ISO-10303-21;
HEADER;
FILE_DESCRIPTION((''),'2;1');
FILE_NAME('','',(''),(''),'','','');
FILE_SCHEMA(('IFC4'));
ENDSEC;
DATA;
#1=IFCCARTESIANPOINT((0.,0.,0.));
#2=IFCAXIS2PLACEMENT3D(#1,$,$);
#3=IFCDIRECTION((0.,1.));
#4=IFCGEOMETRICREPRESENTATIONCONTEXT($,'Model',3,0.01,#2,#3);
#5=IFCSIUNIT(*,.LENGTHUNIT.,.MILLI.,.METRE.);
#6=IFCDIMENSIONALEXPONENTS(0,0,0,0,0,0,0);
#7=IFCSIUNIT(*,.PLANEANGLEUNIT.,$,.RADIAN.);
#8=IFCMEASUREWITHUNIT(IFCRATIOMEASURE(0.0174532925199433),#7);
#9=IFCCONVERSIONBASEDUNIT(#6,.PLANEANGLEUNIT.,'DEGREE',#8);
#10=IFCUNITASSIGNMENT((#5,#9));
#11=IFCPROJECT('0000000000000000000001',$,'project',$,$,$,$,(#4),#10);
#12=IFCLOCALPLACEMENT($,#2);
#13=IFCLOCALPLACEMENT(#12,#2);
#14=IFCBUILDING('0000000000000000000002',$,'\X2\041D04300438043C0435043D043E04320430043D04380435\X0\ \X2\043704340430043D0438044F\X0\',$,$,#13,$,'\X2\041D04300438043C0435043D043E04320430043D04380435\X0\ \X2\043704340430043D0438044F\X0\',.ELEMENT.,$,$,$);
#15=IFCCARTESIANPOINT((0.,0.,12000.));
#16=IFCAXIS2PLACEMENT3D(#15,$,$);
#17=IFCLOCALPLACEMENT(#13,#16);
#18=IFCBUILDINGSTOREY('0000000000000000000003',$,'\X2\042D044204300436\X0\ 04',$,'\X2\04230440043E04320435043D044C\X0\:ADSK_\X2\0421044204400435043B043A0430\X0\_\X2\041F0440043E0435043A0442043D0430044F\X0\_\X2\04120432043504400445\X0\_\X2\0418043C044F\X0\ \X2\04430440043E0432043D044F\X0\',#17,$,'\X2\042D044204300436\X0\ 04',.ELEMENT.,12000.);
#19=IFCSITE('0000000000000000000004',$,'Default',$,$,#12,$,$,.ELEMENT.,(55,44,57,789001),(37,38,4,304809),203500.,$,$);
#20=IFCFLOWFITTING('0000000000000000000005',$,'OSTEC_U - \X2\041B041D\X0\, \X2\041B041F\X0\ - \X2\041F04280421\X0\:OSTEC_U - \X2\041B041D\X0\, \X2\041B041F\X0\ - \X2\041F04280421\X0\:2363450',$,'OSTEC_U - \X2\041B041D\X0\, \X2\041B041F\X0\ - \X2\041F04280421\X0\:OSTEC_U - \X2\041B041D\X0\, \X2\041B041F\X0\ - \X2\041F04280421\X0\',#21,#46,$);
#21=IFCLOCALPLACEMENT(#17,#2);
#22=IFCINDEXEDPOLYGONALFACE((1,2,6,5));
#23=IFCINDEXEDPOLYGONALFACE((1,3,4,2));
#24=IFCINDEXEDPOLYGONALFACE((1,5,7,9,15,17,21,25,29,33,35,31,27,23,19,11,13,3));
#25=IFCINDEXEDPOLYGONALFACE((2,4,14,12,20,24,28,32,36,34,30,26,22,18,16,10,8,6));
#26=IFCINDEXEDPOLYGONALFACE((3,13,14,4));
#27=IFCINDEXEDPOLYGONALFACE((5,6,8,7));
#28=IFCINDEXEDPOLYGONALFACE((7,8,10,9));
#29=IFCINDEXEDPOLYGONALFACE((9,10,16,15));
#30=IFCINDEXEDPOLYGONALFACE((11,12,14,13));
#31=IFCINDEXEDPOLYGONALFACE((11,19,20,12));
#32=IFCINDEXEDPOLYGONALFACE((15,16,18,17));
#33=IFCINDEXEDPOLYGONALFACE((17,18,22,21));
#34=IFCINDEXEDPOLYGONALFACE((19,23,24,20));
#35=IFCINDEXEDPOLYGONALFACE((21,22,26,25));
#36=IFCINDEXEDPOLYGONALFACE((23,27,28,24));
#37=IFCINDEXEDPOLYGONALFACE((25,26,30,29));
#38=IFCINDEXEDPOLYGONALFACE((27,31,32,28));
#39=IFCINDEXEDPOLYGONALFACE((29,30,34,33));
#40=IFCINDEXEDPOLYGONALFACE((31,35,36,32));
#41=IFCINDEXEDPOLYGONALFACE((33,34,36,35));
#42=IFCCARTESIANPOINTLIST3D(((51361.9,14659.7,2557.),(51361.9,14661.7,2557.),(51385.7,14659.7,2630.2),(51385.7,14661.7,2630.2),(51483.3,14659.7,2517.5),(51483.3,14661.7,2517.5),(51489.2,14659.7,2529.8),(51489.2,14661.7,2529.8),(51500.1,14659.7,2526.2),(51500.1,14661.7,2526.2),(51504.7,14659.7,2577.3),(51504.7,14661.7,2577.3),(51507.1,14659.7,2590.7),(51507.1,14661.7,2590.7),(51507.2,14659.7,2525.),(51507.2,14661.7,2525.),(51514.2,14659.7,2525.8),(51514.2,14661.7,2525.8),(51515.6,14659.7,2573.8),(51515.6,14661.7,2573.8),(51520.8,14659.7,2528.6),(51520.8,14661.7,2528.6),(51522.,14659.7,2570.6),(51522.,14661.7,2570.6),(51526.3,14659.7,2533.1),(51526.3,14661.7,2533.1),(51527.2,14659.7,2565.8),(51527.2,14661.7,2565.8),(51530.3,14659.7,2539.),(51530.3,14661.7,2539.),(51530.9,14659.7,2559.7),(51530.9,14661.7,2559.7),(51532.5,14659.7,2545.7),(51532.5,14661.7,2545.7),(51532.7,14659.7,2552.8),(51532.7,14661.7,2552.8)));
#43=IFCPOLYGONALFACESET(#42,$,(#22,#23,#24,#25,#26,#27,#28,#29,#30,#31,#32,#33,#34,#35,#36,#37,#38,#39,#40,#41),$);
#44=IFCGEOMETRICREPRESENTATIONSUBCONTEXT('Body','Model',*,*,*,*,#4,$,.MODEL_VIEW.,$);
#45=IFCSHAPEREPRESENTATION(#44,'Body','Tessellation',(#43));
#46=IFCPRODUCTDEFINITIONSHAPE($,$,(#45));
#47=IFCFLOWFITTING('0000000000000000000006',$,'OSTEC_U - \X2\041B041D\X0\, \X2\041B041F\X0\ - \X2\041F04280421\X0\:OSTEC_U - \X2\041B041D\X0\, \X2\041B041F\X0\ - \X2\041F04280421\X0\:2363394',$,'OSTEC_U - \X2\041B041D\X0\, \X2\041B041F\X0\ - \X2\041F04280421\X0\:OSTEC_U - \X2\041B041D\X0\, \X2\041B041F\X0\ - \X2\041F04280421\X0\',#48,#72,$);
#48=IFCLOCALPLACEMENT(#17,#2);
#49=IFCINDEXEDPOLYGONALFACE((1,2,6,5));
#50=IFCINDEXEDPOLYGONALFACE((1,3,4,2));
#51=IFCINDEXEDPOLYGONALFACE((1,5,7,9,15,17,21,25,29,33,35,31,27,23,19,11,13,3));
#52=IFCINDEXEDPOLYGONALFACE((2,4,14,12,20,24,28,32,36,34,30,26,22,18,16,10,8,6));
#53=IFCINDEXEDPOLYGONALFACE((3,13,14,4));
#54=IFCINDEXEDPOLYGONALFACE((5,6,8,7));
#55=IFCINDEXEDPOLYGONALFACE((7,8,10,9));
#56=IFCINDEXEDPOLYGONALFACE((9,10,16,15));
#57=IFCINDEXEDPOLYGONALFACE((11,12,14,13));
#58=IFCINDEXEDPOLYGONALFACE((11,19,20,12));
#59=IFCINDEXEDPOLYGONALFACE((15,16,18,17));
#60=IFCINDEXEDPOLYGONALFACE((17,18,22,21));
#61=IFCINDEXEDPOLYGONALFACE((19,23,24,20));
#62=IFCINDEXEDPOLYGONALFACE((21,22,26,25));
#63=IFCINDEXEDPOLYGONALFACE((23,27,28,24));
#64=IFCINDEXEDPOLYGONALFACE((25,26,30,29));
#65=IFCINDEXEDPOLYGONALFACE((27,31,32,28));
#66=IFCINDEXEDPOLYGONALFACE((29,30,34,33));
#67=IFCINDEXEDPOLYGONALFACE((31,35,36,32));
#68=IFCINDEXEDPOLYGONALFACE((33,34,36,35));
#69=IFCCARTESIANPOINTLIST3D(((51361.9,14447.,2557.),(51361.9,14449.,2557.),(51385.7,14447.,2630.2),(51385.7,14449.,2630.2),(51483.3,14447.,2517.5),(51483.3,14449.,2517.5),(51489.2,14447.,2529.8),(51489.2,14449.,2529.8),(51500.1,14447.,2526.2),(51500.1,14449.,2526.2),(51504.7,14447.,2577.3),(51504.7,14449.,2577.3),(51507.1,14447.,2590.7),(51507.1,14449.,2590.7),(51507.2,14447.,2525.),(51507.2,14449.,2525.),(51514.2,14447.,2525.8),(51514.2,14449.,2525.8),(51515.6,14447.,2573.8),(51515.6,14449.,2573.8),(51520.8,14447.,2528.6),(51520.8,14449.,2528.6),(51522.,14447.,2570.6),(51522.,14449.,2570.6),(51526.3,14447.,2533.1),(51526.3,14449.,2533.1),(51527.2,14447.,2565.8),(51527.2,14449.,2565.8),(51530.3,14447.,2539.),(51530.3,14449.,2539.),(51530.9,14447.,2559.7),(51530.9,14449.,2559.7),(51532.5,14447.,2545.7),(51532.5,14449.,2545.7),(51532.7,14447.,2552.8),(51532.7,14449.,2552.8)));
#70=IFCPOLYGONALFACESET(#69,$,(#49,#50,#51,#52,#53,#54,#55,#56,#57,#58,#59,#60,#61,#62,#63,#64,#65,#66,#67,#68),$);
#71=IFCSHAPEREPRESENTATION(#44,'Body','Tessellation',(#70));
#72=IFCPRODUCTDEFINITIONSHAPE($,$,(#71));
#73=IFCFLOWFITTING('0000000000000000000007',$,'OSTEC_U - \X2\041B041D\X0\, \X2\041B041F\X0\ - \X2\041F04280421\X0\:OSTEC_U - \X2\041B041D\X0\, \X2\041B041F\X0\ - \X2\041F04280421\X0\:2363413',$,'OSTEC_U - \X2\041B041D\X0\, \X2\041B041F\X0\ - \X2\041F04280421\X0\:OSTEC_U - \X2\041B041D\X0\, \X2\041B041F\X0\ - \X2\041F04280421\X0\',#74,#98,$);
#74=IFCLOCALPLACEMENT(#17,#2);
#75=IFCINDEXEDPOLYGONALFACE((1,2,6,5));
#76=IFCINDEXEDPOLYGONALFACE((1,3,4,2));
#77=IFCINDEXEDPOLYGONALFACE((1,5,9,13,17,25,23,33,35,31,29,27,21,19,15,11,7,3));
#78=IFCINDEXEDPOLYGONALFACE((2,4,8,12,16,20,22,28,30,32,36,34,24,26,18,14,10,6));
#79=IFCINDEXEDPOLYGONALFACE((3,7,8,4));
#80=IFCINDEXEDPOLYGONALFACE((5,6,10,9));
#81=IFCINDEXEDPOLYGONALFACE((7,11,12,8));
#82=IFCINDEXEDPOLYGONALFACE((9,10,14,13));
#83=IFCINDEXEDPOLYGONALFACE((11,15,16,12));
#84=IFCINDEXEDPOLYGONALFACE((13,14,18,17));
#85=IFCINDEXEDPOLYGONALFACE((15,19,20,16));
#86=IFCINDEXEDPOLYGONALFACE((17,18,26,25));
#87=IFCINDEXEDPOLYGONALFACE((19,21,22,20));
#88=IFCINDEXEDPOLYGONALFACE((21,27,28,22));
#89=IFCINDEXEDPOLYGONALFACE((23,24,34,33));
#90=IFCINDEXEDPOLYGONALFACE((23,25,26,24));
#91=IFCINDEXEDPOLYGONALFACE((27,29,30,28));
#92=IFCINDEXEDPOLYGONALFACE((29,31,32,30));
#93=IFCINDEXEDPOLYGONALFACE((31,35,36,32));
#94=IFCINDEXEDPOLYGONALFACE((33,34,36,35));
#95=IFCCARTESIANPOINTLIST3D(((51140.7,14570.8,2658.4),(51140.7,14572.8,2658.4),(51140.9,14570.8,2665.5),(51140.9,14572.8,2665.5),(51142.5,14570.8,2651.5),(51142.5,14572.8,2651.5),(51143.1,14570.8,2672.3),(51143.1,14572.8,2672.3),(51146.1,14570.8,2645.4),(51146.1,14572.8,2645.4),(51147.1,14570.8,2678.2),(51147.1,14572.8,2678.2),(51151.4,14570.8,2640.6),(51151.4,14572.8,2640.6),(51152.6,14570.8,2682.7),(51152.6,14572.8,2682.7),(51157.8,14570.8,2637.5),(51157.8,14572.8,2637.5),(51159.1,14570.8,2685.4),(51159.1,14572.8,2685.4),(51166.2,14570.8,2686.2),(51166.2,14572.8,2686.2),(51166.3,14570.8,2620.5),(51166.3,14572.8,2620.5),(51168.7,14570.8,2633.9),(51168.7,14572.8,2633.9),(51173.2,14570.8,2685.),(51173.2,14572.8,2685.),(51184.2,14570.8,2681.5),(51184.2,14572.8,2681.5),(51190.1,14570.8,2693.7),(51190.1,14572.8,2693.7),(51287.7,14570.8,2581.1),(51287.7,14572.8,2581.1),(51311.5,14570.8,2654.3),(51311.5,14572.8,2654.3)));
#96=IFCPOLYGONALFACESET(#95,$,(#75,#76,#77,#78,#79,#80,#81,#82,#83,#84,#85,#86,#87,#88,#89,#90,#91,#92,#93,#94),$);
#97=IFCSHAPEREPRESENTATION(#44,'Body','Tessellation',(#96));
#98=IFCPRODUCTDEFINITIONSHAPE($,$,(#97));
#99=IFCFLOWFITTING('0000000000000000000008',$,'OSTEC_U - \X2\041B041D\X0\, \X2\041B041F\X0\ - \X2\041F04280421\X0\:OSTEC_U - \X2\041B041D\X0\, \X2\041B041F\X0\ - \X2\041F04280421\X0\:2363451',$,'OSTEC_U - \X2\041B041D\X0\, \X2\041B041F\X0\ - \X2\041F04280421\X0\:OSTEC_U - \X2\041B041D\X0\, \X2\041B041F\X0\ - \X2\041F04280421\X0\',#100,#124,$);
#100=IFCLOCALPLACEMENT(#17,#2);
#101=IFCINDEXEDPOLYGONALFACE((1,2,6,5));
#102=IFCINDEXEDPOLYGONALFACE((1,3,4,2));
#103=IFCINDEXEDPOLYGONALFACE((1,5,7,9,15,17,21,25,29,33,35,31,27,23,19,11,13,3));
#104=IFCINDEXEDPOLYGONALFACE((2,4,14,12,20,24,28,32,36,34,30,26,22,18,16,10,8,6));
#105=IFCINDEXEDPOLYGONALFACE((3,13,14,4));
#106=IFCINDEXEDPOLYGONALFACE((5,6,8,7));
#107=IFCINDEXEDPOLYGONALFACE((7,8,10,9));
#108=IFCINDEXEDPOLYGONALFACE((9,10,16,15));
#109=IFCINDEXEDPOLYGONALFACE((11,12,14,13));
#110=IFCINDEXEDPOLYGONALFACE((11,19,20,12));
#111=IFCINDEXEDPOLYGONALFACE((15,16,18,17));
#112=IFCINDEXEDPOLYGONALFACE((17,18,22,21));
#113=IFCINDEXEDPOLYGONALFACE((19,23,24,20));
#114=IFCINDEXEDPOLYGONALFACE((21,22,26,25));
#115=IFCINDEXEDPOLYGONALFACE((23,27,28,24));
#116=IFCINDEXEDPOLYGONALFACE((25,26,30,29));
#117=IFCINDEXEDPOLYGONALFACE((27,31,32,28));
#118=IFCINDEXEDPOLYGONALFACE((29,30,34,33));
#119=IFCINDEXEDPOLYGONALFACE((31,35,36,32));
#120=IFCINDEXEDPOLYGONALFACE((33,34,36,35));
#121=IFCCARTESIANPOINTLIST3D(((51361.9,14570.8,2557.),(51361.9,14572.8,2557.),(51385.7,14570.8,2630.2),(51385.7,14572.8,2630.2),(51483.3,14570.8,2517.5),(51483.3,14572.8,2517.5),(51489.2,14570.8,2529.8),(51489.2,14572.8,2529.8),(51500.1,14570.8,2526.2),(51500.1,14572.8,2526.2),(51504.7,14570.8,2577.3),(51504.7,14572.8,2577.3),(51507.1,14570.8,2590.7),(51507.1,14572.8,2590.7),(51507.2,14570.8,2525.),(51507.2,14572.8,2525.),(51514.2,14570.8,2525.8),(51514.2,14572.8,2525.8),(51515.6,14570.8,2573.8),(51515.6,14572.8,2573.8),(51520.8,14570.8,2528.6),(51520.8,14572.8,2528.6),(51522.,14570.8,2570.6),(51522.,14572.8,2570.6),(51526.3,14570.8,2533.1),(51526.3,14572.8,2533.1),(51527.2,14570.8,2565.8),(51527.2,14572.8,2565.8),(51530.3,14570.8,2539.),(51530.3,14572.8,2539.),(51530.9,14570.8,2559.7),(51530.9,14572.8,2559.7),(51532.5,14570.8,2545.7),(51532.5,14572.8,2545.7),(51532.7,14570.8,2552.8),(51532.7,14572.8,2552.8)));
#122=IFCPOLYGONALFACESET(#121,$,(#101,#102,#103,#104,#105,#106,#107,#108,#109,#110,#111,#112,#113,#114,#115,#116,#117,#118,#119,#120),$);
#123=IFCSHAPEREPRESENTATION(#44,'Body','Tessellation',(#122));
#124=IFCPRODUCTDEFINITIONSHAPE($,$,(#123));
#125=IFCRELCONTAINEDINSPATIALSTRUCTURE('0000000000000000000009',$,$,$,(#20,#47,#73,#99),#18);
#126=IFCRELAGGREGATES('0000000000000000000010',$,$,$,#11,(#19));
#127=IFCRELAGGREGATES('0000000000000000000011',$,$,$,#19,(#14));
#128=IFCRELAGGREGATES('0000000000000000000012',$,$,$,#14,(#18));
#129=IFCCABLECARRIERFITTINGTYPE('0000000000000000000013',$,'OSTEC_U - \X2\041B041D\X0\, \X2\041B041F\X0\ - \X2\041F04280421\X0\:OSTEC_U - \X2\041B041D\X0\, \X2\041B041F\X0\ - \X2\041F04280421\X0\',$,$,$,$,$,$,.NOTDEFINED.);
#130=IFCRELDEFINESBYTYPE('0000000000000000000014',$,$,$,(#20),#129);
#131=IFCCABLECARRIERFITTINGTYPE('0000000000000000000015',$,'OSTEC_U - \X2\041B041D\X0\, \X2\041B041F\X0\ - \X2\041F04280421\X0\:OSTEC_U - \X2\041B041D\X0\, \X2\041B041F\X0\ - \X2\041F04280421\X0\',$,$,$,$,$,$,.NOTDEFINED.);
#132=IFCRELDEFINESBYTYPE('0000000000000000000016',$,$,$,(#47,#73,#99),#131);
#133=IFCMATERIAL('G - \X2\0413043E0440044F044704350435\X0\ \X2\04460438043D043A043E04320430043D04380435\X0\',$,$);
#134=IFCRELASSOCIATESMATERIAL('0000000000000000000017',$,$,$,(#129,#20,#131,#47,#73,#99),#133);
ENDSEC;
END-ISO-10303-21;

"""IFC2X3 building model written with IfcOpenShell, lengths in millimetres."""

from ifc_helpers import new_model, entity, si_unit, converted_unit, direction, frame, frame_2d, origin, place, context, subcontext, project, spatial, polyline, circle_curve, parameter, trimmed, segment, composite_curve, outline, extrude, source, transform, mapped, material, type_object, type_shapes, element, save


model = new_model("IFC2X3")

# Units and contexts
model_context = context("Model", 3, precision=0.01, world=origin(), true_north=direction((0.0, 1.0)))
body_context = subcontext(model_context, "Body", "Model", "MODEL_VIEW")
ifc_project = project(units=[si_unit("LENGTHUNIT", "METRE", prefix="MILLI"), converted_unit("PLANEANGLEUNIT", "DEGREE", entity("IfcRatioMeasure", 0.0174532925199433), si_unit("PLANEANGLEUNIT", "RADIAN"), dimensions=[0, 0, 0, 0, 0, 0, 0])], contexts=[model_context])

# Site, building, storey
site_placement = place(None, frame((0.0, 0.0, 0.0)))
site = spatial("IfcSite", under=ifc_project, at=site_placement, Name="Default", CompositionType="ELEMENT", RefLatitude=(55, 44, 57, 789001), RefLongitude=(37, 38, 4, 304809), RefElevation=203500.0)
building_placement = place(site_placement, origin())
building = spatial("IfcBuilding", under=site, at=building_placement, Name="Наименование здания", LongName="Наименование здания", CompositionType="ELEMENT")
storey_placement = place(building_placement, frame((0.0, 0.0, 12000.0)))
storey = spatial("IfcBuildingStorey", under=building, at=storey_placement, Name="Этаж 04", ObjectType="Уровень:ADSK_Стрелка_Проектная_Вверх_Имя уровня", LongName="Этаж 04", CompositionType="ELEMENT", Elevation=12000.0)

# Flow fittings
ifc_material = material(Name="G - Горячее цинкование")
cable_carrier_fitting_type_1 = type_object("IfcCableCarrierFittingType", Name="OSTEC_U - ЛН, ЛП - ПШС:OSTEC_U - ЛН, ЛП - ПШС", PredefinedType="NOTDEFINED", material=ifc_material)
shared_shape_1 = source(origin(), body_context, "Body", "SweptSolid", [
    extrude(outline(composite_curve([segment(trimmed(circle_curve(frame_2d((-41.5, 0.0), x_axis=(1.0, 0.0)), 25.0), [parameter(90.0)], [parameter(270.0)], True, "PARAMETER"), True, "CONTINUOUS"), segment(polyline([(-41.5, -25.0), (-30.0, -25.0)]), True, "CONTINUOUS"), segment(polyline([(-30.0, -25.0), (-28.1, -38.5)]), True, "CONTINUOUS"), segment(polyline([(-28.1, -38.5), (99.5, -38.5)]), True, "CONTINUOUS"), segment(polyline([(99.5, -38.5), (99.5, 38.5)]), True, "CONTINUOUS"), segment(polyline([(99.5, 38.5), (-28.1, 38.5)]), True, "CONTINUOUS"), segment(polyline([(-28.1, 38.5), (-30.0, 25.0)]), True, "CONTINUOUS"), segment(polyline([(-30.0, 25.0), (-41.5, 25.0)]), True, "CONTINUOUS")], self_intersect=False)), frame((41.5, 0.0, 0.0), z_axis=(0.0, 0.0, -1.0), x_axis=(1.0, 0.0, 0.0)), (0.0, 0.0, -1.0), 2.0),
])
type_shapes(cable_carrier_fitting_type_1, [shared_shape_1])
for number, where, z_axis, x_axis, name in (
    (1, (51507.9, 14659.7, 2550.0), (0.0, 1.0, 0.0), (-0.951057, 0.0, 0.309017), "OSTEC_U - ЛН, ЛП - ПШС:OSTEC_U - ЛН, ЛП - ПШС:2363450"),
):
    element("IfcFlowFitting", number, at=place(storey_placement, frame(where, z_axis=z_axis, x_axis=x_axis)), inside=storey, type_object=cable_carrier_fitting_type_1, material=ifc_material, Name=name, ObjectType="OSTEC_U - ЛН, ЛП - ПШС:OSTEC_U - ЛН, ЛП - ПШС", context=body_context, shape_type="MappedRepresentation", body=[
        mapped(shared_shape_1, transform((0.0, 0.0, 0.0), scale=1.0)),
    ])
cable_carrier_fitting_type_2 = type_object("IfcCableCarrierFittingType", Name="OSTEC_U - ЛН, ЛП - ПШС:OSTEC_U - ЛН, ЛП - ПШС", PredefinedType="NOTDEFINED", material=ifc_material)
shared_shape_2 = source(origin(), body_context, "Body", "SweptSolid", [
    extrude(outline(composite_curve([segment(trimmed(circle_curve(frame_2d((-41.5, 0.0), x_axis=(1.0, 0.0)), 25.0), [parameter(90.0)], [parameter(270.0)], True, "PARAMETER"), True, "CONTINUOUS"), segment(polyline([(-41.5, -25.0), (-30.0, -25.0)]), True, "CONTINUOUS"), segment(polyline([(-30.0, -25.0), (-28.1, -38.5)]), True, "CONTINUOUS"), segment(polyline([(-28.1, -38.5), (99.5, -38.5)]), True, "CONTINUOUS"), segment(polyline([(99.5, -38.5), (99.5, 38.5)]), True, "CONTINUOUS"), segment(polyline([(99.5, 38.5), (-28.1, 38.5)]), True, "CONTINUOUS"), segment(polyline([(-28.1, 38.5), (-30.0, 25.0)]), True, "CONTINUOUS"), segment(polyline([(-30.0, 25.0), (-41.5, 25.0)]), True, "CONTINUOUS")], self_intersect=False)), frame((41.5, 0.0, 0.0)), (0.0, 0.0, 1.0), 2.0),
])
type_shapes(cable_carrier_fitting_type_2, [shared_shape_2])
for number, where, z_axis, x_axis, name in (
    (2, (51507.9, 14449.0, 2550.0), (0.0, -1.0, 0.0), (-0.951057, 0.0, 0.309017), "OSTEC_U - ЛН, ЛП - ПШС:OSTEC_U - ЛН, ЛП - ПШС:2363394"),
    (3, (51165.5, 14572.8, 2661.2), (0.0, -1.0, 0.0), (0.951057, 0.0, -0.309017), "OSTEC_U - ЛН, ЛП - ПШС:OSTEC_U - ЛН, ЛП - ПШС:2363413"),
    (4, (51507.9, 14572.8, 2550.0), (0.0, -1.0, 0.0), (-0.951057, 0.0, 0.309017), "OSTEC_U - ЛН, ЛП - ПШС:OSTEC_U - ЛН, ЛП - ПШС:2363451"),
):
    element("IfcFlowFitting", number, at=place(storey_placement, frame(where, z_axis=z_axis, x_axis=x_axis)), inside=storey, type_object=cable_carrier_fitting_type_2, material=ifc_material, Name=name, ObjectType="OSTEC_U - ЛН, ЛП - ПШС:OSTEC_U - ЛН, ЛП - ПШС", context=body_context, shape_type="MappedRepresentation", body=[
        mapped(shared_shape_2, transform((0.0, 0.0, 0.0), scale=1.0)),
    ])

save(model, "model.ifc")
